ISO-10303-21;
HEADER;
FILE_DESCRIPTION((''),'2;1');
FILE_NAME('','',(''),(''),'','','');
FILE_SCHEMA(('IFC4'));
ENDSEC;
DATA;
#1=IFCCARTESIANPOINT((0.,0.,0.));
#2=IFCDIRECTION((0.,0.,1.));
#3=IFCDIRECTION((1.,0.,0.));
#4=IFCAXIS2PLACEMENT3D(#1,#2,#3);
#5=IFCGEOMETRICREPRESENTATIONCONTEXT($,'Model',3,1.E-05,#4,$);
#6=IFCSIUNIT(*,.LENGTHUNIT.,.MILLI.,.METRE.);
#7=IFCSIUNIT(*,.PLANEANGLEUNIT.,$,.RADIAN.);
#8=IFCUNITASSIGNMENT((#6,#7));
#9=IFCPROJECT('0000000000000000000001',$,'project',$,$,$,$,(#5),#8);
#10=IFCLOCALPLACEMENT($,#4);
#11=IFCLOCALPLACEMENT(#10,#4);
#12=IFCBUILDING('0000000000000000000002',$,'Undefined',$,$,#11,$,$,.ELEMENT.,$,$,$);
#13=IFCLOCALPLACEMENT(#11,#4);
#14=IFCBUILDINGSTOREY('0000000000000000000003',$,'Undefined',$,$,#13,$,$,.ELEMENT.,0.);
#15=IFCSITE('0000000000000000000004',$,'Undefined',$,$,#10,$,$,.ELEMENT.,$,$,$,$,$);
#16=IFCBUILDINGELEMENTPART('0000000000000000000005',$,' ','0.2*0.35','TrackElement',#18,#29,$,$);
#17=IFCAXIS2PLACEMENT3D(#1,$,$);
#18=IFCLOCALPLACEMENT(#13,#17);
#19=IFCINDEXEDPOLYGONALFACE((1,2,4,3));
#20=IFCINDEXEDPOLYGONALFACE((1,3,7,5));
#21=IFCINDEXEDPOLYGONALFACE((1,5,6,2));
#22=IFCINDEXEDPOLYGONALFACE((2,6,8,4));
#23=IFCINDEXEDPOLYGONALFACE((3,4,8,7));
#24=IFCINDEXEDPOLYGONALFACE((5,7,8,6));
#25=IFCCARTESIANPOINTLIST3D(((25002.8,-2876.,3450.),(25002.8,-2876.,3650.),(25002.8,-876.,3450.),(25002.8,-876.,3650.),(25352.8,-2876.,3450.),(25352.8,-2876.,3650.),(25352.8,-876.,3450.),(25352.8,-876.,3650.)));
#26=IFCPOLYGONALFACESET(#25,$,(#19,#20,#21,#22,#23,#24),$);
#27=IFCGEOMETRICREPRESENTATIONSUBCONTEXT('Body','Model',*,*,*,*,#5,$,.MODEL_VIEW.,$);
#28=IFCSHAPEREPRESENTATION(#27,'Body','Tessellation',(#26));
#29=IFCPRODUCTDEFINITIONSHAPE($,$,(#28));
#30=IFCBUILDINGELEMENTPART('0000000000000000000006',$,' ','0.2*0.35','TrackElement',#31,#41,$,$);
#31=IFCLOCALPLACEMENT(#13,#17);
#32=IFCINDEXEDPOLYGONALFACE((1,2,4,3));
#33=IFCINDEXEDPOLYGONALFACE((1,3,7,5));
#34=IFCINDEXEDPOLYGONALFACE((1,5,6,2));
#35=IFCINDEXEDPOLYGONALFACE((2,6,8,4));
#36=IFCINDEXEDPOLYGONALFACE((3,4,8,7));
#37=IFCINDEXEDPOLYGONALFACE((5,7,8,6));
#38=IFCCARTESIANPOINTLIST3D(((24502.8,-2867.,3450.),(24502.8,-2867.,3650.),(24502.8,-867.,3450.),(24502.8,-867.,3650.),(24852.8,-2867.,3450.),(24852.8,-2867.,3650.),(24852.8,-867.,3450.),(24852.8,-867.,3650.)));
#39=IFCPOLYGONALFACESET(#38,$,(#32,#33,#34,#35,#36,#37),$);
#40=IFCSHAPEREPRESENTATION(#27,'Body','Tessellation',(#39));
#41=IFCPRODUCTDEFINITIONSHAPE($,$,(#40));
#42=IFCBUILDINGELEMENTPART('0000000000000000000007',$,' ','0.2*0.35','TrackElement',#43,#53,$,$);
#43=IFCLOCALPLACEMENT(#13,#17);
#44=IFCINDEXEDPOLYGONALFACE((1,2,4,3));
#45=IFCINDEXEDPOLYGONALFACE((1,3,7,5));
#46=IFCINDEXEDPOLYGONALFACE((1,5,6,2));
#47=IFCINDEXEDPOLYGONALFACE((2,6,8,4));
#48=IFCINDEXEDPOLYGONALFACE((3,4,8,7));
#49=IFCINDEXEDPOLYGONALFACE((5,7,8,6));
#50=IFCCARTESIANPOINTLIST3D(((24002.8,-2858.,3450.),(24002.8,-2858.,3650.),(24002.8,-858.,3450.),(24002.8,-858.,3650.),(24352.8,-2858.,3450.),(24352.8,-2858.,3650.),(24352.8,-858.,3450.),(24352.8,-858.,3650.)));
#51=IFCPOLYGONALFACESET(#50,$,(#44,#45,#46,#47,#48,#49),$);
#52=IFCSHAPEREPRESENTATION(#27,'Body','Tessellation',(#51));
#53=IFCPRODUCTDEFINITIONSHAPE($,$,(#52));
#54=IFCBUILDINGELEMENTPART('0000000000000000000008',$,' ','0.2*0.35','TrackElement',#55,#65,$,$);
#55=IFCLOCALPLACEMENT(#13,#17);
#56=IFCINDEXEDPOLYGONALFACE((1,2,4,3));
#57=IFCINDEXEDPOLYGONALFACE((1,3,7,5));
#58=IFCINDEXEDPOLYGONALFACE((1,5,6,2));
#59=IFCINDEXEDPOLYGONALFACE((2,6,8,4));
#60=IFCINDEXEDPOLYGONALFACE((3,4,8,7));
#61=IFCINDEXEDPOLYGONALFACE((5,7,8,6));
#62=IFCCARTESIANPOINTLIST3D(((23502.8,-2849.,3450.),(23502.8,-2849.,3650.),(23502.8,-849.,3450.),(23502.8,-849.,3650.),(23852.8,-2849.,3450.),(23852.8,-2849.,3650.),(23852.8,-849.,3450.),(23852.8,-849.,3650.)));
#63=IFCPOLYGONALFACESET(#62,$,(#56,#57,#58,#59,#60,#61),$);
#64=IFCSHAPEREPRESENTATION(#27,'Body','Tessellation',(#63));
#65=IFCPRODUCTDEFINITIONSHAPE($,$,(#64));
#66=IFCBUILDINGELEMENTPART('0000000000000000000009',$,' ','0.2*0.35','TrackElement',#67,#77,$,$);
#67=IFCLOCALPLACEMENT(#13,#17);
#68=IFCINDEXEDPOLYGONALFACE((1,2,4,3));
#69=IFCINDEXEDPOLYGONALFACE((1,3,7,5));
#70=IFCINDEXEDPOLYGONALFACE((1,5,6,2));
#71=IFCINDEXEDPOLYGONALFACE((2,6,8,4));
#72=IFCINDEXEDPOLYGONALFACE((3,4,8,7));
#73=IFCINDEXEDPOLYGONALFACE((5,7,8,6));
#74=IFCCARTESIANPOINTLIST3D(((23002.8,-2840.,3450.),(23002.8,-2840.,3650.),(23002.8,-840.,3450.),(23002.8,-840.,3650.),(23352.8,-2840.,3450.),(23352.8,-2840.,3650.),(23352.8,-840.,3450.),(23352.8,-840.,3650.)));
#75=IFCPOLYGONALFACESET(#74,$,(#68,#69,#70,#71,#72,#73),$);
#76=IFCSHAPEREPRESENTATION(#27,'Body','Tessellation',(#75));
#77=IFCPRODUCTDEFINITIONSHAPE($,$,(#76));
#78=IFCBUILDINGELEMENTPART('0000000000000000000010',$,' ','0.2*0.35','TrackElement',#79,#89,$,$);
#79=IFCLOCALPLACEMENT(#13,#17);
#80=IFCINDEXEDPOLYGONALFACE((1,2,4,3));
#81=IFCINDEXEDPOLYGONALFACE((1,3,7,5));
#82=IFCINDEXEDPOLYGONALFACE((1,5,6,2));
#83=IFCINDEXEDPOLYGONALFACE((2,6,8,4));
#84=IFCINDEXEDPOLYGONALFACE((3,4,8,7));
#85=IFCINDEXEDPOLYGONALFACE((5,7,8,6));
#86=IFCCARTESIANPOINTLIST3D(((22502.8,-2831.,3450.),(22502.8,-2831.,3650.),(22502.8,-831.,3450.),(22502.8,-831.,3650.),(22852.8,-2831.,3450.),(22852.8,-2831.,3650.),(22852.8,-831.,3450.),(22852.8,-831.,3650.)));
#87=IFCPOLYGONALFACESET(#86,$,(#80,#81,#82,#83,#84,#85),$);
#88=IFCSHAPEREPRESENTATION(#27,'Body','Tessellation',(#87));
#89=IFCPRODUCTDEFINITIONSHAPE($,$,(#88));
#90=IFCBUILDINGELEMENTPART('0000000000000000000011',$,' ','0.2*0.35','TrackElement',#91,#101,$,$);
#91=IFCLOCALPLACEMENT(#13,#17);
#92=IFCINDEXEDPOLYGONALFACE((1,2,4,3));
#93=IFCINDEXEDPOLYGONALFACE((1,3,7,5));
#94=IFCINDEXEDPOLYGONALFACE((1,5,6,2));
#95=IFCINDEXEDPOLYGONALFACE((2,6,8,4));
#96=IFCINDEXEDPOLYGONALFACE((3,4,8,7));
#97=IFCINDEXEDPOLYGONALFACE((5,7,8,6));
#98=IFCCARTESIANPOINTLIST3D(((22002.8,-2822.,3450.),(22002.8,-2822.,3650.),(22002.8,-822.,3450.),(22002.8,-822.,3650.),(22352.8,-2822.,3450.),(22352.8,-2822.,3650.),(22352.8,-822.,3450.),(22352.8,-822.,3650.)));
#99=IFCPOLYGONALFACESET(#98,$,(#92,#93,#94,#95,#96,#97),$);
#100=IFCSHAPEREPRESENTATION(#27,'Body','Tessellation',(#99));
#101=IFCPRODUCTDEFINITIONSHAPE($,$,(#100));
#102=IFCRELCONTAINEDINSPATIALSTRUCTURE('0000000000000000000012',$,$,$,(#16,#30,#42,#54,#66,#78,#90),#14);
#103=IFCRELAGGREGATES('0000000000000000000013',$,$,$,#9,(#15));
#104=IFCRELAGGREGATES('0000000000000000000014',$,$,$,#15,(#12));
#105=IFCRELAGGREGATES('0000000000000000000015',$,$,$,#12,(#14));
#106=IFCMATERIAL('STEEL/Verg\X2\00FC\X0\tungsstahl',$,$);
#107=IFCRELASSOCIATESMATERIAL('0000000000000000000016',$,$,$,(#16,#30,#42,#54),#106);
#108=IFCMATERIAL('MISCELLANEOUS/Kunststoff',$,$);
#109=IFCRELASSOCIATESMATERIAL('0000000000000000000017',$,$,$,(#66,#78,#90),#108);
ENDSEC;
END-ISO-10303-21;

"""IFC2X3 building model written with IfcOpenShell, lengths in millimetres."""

from ifc_helpers import new_model, si_unit, frame, origin_with_axes, origin_2d_with_axis, place, context, subcontext, project, spatial, rectangle, extrude, material, element, save


model = new_model("IFC2X3")

# Units and contexts
model_context = context("Model", 3, precision=1e-05, world=origin_with_axes())
body_context = subcontext(model_context, "Body", "Model", "MODEL_VIEW")
ifc_project = project(units=[si_unit("LENGTHUNIT", "METRE", prefix="MILLI"), si_unit("PLANEANGLEUNIT", "RADIAN")], contexts=[model_context])

# Site, building, storey
site_placement = place(None, origin_with_axes())
site = spatial("IfcSite", under=ifc_project, at=site_placement, Name="Undefined", CompositionType="ELEMENT")
building_placement = place(site_placement, origin_with_axes())
building = spatial("IfcBuilding", under=site, at=building_placement, Name="Undefined", CompositionType="ELEMENT")
storey_placement = place(building_placement, origin_with_axes())
storey = spatial("IfcBuildingStorey", under=building, at=storey_placement, Name="Undefined", CompositionType="ELEMENT", Elevation=0.0)

# Building element parts
ifc_material_1 = material(Name="STEEL/Vergütungsstahl")
for number, where, z_axis, x_axis, name in (
    (1, (25177.8, -876.0, 3550.0), (0.0, 0.0, 1.0), (0.0, -1.0, 0.0), " "),
    (2, (24677.8, -867.0, 3550.0), (0.0, 0.0, 1.0), (0.0, -1.0, 0.0), " "),
    (3, (24177.8, -858.0, 3550.0), (0.0, 0.0, 1.0), (0.0, -1.0, 0.0), " "),
    (4, (23677.8, -849.0, 3550.0), (0.0, 0.0, 1.0), (0.0, -1.0, 0.0), " "),
):
    element("IfcBuildingElementPart", number, at=place(storey_placement, frame(where, z_axis=z_axis, x_axis=x_axis)), inside=storey, material=ifc_material_1, Name=name, Description="0.2*0.35", ObjectType="TrackElement", context=body_context, shape_type="SweptSolid", body=[
        extrude(rectangle(XDim=350.0, YDim=200.0, at=origin_2d_with_axis()), frame((2000.0, 0.0, 0.0), z_axis=(-1.0, 0.0, 0.0), x_axis=(0.0, -1.0, 0.0)), (0.0, 0.0, 1.0), 2000.0),
    ])
ifc_material_2 = material(Name="MISCELLANEOUS/Kunststoff")
for number, where, z_axis, x_axis, name in (
    (5, (23177.8, -840.0, 3550.0), (0.0, 0.0, 1.0), (0.0, -1.0, 0.0), " "),
    (6, (22677.8, -831.0, 3550.0), (0.0, 0.0, 1.0), (0.0, -1.0, 0.0), " "),
    (7, (22177.8, -822.0, 3550.0), (0.0, 0.0, 1.0), (0.0, -1.0, 0.0), " "),
):
    element("IfcBuildingElementPart", number, at=place(storey_placement, frame(where, z_axis=z_axis, x_axis=x_axis)), inside=storey, material=ifc_material_2, Name=name, Description="0.2*0.35", ObjectType="TrackElement", context=body_context, shape_type="SweptSolid", body=[
        extrude(rectangle(XDim=350.0, YDim=200.0, at=origin_2d_with_axis()), frame((2000.0, 0.0, 0.0), z_axis=(-1.0, 0.0, 0.0), x_axis=(0.0, -1.0, 0.0)), (0.0, 0.0, 1.0), 2000.0),
    ])

save(model, "model.ifc")
